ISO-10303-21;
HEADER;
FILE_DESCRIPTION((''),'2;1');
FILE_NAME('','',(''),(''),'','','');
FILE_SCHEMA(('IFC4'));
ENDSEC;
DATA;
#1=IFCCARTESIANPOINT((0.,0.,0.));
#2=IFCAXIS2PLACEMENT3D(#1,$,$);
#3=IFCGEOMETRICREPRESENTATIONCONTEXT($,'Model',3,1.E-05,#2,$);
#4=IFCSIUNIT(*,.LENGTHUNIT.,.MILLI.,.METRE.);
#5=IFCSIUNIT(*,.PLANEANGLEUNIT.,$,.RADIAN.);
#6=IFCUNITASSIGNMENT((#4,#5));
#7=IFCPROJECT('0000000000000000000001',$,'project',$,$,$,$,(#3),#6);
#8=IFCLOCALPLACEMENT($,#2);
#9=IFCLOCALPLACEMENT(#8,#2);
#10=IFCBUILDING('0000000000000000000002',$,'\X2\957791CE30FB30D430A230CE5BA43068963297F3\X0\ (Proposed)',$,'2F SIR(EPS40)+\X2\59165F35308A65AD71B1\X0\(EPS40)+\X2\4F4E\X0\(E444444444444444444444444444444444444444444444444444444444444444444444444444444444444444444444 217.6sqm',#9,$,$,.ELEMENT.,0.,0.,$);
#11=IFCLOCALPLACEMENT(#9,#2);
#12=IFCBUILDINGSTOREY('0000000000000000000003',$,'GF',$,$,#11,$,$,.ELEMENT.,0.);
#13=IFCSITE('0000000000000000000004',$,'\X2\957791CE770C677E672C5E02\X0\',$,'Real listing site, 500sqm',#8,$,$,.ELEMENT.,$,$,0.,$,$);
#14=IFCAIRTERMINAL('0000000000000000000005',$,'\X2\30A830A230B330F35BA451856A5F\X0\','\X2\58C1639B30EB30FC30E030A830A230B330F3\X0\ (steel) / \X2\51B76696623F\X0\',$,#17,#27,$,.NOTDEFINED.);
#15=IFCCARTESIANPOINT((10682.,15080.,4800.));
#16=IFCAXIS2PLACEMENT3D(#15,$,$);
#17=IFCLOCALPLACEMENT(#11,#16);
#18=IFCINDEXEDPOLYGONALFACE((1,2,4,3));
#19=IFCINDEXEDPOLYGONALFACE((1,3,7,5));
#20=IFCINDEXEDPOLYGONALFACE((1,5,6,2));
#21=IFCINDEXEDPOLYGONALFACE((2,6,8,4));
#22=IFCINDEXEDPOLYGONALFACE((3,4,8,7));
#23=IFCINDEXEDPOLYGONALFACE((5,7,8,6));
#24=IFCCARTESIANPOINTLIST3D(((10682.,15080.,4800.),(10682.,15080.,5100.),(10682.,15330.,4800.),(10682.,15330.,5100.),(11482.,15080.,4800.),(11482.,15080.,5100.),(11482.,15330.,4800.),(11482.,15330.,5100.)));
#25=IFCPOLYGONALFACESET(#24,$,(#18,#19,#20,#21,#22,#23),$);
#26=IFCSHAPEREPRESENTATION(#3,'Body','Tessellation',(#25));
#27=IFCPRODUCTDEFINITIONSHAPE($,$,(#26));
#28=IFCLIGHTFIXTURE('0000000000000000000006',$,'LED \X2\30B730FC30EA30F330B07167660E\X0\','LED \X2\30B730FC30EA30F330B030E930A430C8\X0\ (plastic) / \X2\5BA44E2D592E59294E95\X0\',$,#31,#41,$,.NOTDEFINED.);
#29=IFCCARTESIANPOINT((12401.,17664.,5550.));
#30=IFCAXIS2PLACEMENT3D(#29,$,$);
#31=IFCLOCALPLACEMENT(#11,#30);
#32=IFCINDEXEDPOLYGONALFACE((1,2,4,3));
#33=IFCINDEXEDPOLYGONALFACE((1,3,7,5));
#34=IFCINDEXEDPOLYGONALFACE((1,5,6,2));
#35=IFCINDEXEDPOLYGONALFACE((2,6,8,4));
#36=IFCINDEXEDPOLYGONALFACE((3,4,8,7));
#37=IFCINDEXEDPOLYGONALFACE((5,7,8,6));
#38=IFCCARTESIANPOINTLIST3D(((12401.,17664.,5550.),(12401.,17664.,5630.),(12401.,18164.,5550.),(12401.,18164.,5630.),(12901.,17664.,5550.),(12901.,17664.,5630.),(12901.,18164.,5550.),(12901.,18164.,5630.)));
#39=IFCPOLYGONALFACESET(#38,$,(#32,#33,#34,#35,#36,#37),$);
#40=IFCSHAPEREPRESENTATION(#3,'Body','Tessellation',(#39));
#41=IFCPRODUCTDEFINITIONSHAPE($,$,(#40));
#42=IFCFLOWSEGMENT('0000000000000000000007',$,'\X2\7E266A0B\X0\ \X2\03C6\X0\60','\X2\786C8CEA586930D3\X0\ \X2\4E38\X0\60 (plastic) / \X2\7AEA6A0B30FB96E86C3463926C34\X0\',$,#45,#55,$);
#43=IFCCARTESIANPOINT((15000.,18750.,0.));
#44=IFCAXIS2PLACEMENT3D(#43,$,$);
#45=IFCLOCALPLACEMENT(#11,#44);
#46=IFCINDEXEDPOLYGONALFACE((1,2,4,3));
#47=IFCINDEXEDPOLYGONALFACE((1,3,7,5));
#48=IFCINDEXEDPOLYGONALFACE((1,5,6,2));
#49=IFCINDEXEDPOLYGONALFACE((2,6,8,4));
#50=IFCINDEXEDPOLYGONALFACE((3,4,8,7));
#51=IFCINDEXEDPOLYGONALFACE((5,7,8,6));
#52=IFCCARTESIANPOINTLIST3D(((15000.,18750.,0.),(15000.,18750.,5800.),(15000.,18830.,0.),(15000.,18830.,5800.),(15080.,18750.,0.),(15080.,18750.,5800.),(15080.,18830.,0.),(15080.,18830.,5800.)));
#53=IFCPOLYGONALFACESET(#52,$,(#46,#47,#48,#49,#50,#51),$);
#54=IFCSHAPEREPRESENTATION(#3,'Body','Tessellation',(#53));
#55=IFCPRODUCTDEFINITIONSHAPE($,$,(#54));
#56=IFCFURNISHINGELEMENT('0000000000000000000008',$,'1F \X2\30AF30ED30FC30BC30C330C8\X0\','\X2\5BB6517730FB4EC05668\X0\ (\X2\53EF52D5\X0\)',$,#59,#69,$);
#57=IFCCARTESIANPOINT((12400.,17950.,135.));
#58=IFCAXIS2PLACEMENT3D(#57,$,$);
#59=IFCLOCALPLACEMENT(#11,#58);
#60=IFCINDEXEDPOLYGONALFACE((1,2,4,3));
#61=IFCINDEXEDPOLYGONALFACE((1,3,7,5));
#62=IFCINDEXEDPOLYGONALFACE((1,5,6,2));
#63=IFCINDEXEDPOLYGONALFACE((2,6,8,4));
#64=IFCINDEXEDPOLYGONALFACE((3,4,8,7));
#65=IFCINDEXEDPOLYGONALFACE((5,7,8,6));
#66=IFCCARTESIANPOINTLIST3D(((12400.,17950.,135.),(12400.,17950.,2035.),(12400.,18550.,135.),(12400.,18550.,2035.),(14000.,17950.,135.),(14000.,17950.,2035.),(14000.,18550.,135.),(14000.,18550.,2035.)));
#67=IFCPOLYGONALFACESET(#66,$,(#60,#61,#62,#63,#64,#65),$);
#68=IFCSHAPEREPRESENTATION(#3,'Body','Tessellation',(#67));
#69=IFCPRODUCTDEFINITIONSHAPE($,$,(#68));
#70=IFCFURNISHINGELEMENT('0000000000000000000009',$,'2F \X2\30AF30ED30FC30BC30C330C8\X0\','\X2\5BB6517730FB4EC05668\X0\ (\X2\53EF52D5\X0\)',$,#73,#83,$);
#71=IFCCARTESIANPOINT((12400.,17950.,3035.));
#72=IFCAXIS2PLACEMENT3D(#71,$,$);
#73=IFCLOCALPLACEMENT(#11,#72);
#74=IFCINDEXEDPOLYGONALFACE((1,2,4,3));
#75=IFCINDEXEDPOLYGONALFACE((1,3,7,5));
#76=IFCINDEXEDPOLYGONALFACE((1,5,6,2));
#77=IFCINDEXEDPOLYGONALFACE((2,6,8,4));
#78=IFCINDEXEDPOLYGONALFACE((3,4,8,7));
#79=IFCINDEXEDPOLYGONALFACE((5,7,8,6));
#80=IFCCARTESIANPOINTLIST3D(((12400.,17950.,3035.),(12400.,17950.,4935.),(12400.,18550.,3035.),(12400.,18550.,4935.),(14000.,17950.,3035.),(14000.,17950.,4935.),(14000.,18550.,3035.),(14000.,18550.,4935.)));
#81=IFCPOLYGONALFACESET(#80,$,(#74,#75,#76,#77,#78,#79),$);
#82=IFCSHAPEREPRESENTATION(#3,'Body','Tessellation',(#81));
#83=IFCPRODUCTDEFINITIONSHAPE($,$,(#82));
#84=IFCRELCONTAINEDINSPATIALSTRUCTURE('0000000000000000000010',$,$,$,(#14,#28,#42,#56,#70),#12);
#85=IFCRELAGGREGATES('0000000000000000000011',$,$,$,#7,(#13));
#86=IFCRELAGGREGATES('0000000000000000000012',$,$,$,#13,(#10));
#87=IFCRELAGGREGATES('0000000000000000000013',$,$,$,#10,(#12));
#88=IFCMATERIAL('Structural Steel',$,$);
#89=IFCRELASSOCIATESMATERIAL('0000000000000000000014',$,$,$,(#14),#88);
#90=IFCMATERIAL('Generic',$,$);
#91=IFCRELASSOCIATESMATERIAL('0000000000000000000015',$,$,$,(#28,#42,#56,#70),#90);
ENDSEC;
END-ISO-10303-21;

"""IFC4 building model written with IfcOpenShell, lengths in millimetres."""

from ifc_helpers import new_model, si_unit, frame, frame_2d, origin, place, context, project, spatial, rectangle, extrude, material, element, save


model = new_model("IFC4")

# Units and contexts
model_context = context("Model", 3, precision=1e-05, world=origin())
ifc_project = project(units=[si_unit("LENGTHUNIT", "METRE", prefix="MILLI"), si_unit("PLANEANGLEUNIT", "RADIAN")], contexts=[model_context])

# Site, building, storey
site_placement = place(None, origin())
site = spatial("IfcSite", under=ifc_project, at=site_placement, Name="長野県松本市", ObjectType="Real listing site, 500sqm", CompositionType="ELEMENT", RefElevation=0.0)
building_placement = place(site_placement, origin())
building = spatial("IfcBuilding", under=site, at=building_placement, Name="長野・ピアノ室と防音 (Proposed)", ObjectType="2F SIR(EPS40)+外張り断熱(EPS40)+低(E444444444444444444444444444444444444444444444444444444444444444444444444444444444444444444444 217.6sqm", CompositionType="ELEMENT", ElevationOfRefHeight=0.0, ElevationOfTerrain=0.0)
storey_placement = place(building_placement, origin())
storey = spatial("IfcBuildingStorey", under=building, at=storey_placement, Name="GF", CompositionType="ELEMENT", Elevation=0.0)

# Shared definitions
ifc_material_1 = material(Name="Generic")

# Shared definitions
ifc_material_2 = material(Name="Structural Steel")

# Air terminal
air_terminal_1_placement = place(storey_placement, frame((10682.0, 15080.0, 4800.0)))
element("IfcAirTerminal", 1, at=air_terminal_1_placement, inside=storey, material=ifc_material_2, Name="エアコン室内機", Description="壁掛ルームエアコン (steel) / 冷暖房", PredefinedType="NOTDEFINED", context=model_context, shape_type="SweptSolid", body=[
    extrude(rectangle(XDim=800.0, YDim=250.0, at=frame_2d((400.0, 125.0))), frame((10682.0, 15080.0, 4800.0)), (0.0, 0.0, 1.0), 300.0),
])

# Light fixture
light_fixture_1_placement = place(storey_placement, frame((12401.0, 17664.0, 5550.0)))
element("IfcLightFixture", 2, at=light_fixture_1_placement, inside=storey, material=ifc_material_1, Name="LED シーリング照明", Description="LED シーリングライト (plastic) / 室中央天井", PredefinedType="NOTDEFINED", context=model_context, shape_type="SweptSolid", body=[
    extrude(rectangle(XDim=500.0, YDim=500.0, at=frame_2d((250.0, 250.0))), frame((12401.0, 17664.0, 5550.0)), (0.0, 0.0, 1.0), 80.0),
])

# Flow segment
flow_segment_placement = place(storey_placement, frame((15000.0, 18750.0, 0.0)))
element("IfcFlowSegment", 3, at=flow_segment_placement, inside=storey, material=ifc_material_1, Name="縦樋 φ60", Description="硬質塩ビ 丸60 (plastic) / 竪樋・雨水排水", context=model_context, shape_type="SweptSolid", body=[
    extrude(rectangle(XDim=80.0, YDim=80.0, at=frame_2d((40.0, 40.0))), frame((15000.0, 18750.0, 0.0)), (0.0, 0.0, 1.0), 5800.0),
])

# Furnishing elements
furnishing_1_placement = place(storey_placement, frame((12400.0, 17950.0, 135.0)))
element("IfcFurnishingElement", 4, at=furnishing_1_placement, inside=storey, material=ifc_material_1, Name="1F クローゼット", Description="家具・什器 (可動)", context=model_context, shape_type="SweptSolid", body=[
    extrude(rectangle(XDim=1600.0, YDim=600.0, at=frame_2d((800.0, 300.0))), frame((12400.0, 17950.0, 135.0)), (0.0, 0.0, 1.0), 1900.0),
])
furnishing_2_placement = place(storey_placement, frame((12400.0, 17950.0, 3035.0)))
element("IfcFurnishingElement", 5, at=furnishing_2_placement, inside=storey, material=ifc_material_1, Name="2F クローゼット", Description="家具・什器 (可動)", context=model_context, shape_type="SweptSolid", body=[
    extrude(rectangle(XDim=1600.0, YDim=600.0, at=frame_2d((800.0, 300.0))), frame((12400.0, 17950.0, 3035.0)), (0.0, 0.0, 1.0), 1900.0),
])

save(model, "model.ifc")
